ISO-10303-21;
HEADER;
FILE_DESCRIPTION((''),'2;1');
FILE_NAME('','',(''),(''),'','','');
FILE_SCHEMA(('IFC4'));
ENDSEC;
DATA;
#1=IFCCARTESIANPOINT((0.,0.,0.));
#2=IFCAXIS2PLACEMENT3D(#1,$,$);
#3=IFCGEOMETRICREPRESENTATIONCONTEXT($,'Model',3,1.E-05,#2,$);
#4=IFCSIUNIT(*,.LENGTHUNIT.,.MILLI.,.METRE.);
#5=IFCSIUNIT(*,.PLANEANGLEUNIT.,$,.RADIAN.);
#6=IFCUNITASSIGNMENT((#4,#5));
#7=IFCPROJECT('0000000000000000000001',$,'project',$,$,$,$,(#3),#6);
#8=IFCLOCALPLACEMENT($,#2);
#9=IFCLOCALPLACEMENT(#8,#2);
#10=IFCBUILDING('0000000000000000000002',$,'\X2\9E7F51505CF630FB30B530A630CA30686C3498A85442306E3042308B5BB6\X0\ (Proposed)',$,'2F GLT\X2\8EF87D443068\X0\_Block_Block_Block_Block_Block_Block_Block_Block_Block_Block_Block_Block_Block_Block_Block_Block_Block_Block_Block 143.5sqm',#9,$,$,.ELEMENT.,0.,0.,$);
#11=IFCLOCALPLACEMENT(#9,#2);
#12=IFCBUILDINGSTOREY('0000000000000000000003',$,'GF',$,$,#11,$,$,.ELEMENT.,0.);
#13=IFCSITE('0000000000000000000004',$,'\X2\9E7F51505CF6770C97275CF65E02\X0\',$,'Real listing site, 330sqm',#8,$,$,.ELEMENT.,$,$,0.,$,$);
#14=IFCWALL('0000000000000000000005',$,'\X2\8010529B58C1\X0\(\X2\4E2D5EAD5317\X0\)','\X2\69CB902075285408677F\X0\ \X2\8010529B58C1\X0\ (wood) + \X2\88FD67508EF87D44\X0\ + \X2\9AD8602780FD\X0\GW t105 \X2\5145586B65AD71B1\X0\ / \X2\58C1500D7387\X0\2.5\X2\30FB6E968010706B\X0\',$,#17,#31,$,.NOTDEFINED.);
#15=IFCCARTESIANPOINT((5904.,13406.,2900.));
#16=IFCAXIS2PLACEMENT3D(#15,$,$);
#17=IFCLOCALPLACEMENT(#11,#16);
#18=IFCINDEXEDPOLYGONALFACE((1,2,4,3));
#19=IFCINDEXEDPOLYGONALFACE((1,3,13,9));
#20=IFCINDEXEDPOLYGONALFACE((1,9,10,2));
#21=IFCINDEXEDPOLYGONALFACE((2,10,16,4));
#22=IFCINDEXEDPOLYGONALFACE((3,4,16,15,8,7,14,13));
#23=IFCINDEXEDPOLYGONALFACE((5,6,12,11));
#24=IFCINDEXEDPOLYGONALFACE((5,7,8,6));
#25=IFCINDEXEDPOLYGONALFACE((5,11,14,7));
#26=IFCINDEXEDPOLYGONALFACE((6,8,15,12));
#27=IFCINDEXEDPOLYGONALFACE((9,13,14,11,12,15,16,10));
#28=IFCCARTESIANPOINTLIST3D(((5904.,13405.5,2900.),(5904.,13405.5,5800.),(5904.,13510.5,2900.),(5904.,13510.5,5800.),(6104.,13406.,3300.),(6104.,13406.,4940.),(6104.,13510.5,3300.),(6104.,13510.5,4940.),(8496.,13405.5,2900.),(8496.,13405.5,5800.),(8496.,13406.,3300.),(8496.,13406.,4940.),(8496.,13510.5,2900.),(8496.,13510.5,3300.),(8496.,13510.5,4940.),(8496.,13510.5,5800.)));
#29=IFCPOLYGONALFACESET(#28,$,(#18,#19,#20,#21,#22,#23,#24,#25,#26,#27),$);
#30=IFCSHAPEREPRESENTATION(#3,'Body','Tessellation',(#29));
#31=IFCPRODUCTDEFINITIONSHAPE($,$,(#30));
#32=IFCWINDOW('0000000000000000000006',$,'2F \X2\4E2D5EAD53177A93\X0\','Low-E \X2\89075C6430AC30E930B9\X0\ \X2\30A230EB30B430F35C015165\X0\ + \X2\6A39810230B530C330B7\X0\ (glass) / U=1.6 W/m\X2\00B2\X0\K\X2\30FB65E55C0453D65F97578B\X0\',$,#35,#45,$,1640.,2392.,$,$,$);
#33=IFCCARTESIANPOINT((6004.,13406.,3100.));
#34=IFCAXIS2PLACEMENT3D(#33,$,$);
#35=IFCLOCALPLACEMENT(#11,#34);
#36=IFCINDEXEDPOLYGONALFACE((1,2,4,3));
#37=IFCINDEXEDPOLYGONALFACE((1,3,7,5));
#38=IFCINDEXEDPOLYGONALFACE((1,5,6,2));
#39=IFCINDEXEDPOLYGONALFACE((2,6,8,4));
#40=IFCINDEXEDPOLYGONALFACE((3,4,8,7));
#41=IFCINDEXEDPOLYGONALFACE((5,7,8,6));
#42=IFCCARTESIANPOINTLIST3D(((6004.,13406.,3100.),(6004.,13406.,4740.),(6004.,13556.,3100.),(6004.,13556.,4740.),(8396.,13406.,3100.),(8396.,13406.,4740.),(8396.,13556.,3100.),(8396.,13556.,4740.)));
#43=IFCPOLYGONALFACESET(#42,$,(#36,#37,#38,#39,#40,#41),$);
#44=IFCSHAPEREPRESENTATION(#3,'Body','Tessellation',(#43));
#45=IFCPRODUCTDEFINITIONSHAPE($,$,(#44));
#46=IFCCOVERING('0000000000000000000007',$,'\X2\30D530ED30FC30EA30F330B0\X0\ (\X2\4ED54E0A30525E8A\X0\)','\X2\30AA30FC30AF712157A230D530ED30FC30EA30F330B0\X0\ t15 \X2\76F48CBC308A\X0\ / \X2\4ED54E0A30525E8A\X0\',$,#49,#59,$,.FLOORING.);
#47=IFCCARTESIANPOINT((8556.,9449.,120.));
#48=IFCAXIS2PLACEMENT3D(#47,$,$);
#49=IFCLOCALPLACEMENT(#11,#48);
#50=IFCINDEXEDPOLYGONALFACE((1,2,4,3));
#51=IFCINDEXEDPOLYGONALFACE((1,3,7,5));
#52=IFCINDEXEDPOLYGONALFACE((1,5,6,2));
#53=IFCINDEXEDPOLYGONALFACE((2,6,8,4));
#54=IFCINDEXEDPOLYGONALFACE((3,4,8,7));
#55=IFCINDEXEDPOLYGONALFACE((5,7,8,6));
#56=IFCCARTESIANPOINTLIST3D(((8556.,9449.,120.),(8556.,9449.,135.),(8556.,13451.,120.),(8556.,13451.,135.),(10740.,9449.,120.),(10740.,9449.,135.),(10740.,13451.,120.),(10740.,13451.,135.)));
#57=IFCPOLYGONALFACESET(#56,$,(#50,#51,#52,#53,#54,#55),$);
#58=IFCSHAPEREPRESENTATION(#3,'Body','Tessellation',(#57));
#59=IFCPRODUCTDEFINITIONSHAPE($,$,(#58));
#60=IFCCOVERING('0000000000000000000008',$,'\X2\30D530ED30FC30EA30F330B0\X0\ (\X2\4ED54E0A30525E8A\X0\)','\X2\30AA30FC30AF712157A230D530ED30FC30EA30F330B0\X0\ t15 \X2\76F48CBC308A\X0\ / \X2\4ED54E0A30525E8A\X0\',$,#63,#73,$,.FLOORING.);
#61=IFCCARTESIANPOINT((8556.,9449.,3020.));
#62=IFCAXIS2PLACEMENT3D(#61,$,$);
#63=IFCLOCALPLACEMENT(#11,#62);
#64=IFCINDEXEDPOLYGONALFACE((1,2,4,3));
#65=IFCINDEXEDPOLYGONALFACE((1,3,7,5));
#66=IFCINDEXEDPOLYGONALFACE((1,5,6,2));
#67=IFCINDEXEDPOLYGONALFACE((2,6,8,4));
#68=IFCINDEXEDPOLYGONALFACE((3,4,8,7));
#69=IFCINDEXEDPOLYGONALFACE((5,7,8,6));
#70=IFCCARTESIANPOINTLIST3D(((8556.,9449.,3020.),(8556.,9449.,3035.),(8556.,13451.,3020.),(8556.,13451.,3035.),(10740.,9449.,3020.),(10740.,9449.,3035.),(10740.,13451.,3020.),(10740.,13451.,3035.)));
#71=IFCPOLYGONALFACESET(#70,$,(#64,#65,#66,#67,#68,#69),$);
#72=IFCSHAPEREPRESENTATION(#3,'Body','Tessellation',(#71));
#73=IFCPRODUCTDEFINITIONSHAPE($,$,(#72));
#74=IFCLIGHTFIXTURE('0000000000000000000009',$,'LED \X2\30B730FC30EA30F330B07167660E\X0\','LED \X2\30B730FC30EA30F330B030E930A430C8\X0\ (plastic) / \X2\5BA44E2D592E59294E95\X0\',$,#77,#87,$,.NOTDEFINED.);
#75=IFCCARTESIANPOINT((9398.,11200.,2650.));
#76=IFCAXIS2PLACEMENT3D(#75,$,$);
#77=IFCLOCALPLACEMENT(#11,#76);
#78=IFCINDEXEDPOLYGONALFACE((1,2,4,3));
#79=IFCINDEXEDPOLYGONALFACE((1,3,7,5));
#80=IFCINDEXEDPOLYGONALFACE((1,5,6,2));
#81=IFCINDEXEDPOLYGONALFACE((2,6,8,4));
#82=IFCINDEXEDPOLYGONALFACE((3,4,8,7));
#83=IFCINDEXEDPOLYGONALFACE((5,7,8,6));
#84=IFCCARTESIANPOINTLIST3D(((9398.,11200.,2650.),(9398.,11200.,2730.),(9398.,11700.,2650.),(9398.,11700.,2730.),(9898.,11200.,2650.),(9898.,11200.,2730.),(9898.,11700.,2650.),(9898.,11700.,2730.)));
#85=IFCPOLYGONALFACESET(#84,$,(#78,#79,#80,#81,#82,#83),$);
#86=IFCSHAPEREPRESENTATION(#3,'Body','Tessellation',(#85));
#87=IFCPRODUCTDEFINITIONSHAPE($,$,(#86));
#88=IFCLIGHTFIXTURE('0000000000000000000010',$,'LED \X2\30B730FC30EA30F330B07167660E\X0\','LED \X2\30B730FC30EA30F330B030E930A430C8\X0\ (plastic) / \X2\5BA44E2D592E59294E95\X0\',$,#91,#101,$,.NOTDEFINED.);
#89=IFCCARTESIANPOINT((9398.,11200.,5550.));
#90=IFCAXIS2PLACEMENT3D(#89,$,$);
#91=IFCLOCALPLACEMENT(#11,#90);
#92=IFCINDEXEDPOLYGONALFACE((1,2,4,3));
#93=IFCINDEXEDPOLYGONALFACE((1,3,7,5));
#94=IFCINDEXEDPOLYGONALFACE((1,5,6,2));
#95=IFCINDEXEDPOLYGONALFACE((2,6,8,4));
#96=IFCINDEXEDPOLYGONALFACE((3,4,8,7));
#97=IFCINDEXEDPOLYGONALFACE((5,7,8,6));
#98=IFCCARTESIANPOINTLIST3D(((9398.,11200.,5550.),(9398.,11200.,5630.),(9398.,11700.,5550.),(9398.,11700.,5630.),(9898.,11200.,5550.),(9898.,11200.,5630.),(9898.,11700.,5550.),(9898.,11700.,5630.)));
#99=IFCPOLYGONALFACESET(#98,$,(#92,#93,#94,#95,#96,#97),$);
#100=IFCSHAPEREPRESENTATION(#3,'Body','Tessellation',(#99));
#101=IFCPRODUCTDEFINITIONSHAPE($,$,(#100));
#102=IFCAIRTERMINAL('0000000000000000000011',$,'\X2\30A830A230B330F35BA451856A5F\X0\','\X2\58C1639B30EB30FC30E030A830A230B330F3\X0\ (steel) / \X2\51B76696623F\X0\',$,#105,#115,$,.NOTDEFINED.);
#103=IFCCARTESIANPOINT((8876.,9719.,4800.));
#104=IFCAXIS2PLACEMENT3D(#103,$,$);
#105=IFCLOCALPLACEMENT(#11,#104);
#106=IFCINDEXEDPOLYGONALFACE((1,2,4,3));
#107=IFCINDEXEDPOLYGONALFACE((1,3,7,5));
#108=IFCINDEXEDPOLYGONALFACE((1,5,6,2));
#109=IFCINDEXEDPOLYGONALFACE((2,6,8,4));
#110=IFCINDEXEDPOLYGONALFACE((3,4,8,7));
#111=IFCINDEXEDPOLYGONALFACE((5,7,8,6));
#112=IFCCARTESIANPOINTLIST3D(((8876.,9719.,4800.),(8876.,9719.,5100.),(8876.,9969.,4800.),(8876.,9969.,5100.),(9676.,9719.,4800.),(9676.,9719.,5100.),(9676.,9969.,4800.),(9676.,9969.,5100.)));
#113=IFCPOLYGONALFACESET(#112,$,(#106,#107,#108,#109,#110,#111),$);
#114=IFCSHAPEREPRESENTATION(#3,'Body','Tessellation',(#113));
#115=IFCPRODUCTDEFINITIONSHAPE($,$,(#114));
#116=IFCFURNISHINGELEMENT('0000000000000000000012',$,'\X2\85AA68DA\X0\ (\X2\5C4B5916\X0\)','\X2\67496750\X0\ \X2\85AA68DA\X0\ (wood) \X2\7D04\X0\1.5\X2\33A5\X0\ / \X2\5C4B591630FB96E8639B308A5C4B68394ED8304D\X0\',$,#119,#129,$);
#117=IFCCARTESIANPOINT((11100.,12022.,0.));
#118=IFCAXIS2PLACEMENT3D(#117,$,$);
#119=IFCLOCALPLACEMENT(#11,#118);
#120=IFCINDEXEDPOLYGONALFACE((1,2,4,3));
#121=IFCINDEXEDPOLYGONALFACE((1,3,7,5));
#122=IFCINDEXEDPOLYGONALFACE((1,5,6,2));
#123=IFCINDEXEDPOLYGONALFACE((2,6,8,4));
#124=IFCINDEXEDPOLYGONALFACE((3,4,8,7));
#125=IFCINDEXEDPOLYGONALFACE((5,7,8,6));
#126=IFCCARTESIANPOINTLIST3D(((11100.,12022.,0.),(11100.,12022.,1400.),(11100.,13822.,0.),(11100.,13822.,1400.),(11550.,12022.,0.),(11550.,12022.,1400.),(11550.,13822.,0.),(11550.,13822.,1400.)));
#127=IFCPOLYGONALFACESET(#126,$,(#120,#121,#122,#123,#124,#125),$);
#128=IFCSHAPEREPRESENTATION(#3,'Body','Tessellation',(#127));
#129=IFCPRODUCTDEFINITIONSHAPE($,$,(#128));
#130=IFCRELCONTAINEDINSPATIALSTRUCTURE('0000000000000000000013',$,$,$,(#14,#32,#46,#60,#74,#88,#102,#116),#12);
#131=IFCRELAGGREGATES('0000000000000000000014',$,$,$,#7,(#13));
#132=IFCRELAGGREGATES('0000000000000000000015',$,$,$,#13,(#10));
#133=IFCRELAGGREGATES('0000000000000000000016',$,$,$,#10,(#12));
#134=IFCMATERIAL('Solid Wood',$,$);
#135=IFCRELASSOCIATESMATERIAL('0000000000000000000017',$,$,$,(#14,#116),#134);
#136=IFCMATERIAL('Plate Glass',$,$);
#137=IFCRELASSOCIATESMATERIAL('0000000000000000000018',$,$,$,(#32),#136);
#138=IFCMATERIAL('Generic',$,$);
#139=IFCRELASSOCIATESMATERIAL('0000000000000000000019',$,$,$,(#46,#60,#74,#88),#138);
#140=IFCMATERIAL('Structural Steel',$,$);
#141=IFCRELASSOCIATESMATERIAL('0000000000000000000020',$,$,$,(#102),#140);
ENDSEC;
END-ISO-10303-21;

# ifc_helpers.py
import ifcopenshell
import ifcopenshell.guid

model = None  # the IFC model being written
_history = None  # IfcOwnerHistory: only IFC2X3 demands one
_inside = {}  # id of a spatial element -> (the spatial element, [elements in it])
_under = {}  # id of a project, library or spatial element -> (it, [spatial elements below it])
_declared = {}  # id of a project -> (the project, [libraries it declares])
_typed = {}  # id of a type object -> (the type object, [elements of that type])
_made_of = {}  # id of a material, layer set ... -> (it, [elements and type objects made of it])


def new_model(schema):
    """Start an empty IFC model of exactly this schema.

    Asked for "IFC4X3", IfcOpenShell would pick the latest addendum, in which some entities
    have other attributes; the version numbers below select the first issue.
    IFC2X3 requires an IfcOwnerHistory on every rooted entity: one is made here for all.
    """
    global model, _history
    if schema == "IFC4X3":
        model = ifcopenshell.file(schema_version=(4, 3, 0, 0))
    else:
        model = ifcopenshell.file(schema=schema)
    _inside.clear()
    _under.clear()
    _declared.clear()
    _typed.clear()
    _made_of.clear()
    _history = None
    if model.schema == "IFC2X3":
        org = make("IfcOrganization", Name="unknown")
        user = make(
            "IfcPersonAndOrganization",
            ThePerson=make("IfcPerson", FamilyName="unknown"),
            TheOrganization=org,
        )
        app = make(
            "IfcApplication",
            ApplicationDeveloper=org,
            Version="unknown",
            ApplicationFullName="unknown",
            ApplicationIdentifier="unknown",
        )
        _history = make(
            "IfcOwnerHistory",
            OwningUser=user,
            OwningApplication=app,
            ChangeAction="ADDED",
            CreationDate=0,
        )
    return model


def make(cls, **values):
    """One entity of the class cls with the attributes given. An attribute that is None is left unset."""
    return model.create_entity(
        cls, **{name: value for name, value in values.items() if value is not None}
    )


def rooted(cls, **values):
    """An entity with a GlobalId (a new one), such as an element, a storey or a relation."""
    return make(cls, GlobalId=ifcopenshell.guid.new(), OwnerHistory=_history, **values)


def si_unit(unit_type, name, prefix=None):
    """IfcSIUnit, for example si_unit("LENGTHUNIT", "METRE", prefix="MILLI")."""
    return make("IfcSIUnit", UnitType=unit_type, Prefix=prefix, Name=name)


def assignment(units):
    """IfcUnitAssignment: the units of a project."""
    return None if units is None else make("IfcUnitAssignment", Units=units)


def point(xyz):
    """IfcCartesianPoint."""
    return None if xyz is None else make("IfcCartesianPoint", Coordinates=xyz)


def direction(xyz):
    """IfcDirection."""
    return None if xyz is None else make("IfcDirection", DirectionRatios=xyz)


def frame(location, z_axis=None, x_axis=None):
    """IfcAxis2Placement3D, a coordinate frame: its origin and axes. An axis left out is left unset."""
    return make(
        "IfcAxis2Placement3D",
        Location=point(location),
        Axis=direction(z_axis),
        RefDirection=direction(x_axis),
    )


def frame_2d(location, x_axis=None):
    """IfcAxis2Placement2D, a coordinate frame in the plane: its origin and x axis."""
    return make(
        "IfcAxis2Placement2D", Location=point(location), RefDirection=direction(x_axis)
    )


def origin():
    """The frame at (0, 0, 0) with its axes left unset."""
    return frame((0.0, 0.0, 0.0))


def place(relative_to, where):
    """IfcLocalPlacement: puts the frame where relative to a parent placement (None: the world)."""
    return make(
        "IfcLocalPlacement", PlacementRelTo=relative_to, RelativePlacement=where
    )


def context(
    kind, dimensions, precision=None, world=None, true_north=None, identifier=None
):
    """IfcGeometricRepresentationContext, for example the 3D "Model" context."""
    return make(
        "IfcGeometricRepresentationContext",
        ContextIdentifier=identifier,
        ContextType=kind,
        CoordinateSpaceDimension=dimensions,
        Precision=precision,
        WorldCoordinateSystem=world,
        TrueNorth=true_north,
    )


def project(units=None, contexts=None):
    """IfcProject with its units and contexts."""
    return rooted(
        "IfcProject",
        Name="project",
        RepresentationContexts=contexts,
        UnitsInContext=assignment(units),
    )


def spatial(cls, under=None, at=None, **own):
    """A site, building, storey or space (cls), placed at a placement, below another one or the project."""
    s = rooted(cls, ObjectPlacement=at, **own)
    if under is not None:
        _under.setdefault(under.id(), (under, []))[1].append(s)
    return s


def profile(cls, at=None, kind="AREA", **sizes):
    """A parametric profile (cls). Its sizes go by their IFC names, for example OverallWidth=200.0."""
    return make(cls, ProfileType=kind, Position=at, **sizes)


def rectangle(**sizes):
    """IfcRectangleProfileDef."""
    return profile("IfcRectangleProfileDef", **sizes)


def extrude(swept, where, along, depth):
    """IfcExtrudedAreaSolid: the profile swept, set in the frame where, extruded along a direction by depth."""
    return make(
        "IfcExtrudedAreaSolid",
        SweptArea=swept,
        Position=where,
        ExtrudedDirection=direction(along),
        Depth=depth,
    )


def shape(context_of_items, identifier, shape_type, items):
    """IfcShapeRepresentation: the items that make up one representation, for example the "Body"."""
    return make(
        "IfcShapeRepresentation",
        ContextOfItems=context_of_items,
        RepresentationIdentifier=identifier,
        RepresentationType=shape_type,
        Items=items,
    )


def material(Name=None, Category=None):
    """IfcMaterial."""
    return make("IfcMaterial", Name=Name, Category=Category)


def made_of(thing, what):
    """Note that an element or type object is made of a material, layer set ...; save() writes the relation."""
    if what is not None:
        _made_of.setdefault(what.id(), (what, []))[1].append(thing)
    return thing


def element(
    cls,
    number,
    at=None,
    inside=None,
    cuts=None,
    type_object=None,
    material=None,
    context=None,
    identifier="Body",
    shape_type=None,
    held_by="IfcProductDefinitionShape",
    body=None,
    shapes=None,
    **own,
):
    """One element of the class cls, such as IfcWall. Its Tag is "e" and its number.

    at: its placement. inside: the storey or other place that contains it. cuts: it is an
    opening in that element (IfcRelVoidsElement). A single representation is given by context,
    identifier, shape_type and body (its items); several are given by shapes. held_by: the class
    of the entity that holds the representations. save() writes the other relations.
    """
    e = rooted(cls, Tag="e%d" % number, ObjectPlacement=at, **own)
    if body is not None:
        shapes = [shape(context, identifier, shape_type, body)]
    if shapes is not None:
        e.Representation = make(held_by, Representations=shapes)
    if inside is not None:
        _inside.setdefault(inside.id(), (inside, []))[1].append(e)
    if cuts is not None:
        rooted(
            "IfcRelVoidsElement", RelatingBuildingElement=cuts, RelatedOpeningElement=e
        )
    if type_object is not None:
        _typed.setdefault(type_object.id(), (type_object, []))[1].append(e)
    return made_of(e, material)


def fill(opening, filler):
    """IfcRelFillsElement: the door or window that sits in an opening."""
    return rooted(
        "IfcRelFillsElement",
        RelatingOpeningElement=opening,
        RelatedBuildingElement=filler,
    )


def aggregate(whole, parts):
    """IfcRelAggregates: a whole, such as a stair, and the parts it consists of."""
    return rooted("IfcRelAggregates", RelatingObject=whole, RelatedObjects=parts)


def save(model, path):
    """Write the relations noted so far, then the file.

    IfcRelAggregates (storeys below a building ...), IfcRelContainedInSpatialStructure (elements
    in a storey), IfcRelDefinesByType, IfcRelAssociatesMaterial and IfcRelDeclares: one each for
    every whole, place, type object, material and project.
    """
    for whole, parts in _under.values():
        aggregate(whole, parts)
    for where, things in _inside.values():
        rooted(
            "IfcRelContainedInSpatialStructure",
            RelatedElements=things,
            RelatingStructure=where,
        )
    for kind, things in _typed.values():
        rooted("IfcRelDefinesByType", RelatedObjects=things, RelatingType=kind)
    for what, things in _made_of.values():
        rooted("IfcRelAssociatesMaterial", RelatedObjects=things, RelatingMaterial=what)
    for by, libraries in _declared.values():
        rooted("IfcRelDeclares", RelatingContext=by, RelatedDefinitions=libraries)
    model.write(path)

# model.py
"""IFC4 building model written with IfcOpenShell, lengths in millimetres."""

from ifc_helpers import new_model, si_unit, frame, frame_2d, origin, place, context, project, spatial, rectangle, extrude, material, element, fill, save


model = new_model("IFC4")

# Units and contexts
model_context = context("Model", 3, precision=1e-05, world=origin())
ifc_project = project(units=[si_unit("LENGTHUNIT", "METRE", prefix="MILLI"), si_unit("PLANEANGLEUNIT", "RADIAN")], contexts=[model_context])

# Site, building, storey
site_placement = place(None, origin())
site = spatial("IfcSite", under=ifc_project, at=site_placement, Name="鹿児島県霧島市", ObjectType="Real listing site, 330sqm", CompositionType="ELEMENT", RefElevation=0.0)
building_placement = place(site_placement, origin())
building = spatial("IfcBuilding", under=site, at=building_placement, Name="鹿児島・サウナと水風呂のある家 (Proposed)", ObjectType="2F GLT軸組と_Block_Block_Block_Block_Block_Block_Block_Block_Block_Block_Block_Block_Block_Block_Block_Block_Block_Block_Block 143.5sqm", CompositionType="ELEMENT", ElevationOfRefHeight=0.0, ElevationOfTerrain=0.0)
storey_placement = place(building_placement, origin())
storey = spatial("IfcBuildingStorey", under=building, at=storey_placement, Name="GF", CompositionType="ELEMENT", Elevation=0.0)

# Shared definitions
ifc_material_1 = material(Name="Solid Wood")

# Wall, opening, window
ifc_material_2 = material(Name="Plate Glass")
wall_1_placement = place(storey_placement, frame((5904.0, 13406.0, 2900.0)))
wall_1 = element("IfcWall", 1, at=wall_1_placement, inside=storey, material=ifc_material_1, Name="耐力壁(中庭北)", Description="構造用合板 耐力壁 (wood) + 製材軸組 + 高性能GW t105 充填断熱 / 壁倍率2.5・準耐火", PredefinedType="NOTDEFINED", context=model_context, shape_type="SweptSolid", body=[
    extrude(rectangle(XDim=2592.0, YDim=105.0, at=frame_2d((1296.0, 52.0))), frame((5904.0, 13406.0, 2900.0)), (0.0, 0.0, 1.0), 2900.0),
])
opening_1_placement = place(storey_placement, frame((6004.0, 13406.0, 3100.0)))
opening_1 = element("IfcOpeningElement", 2, at=opening_1_placement, cuts=wall_1, PredefinedType="NOTDEFINED", context=model_context, shape_type="SweptSolid", body=[
    extrude(rectangle(XDim=2392.0, YDim=150.0, at=frame_2d((1196.0, 75.0))), frame((6004.0, 13406.0, 3100.0)), (0.0, 0.0, 1.0), 1640.0),
])
window_1_placement = place(storey_placement, frame((6004.0, 13406.0, 3100.0)))
window_1 = element("IfcWindow", 3, at=window_1_placement, inside=storey, material=ifc_material_2, Name="2F 中庭北窓", Description="Low-E 複層ガラス アルゴン封入 + 樹脂サッシ (glass) / U=1.6 W/m²K・日射取得型", OverallHeight=1640.0, OverallWidth=2392.0, context=model_context, shape_type="SweptSolid", body=[
    extrude(rectangle(XDim=2392.0, YDim=150.0, at=frame_2d((1196.0, 75.0))), frame((6004.0, 13406.0, 3100.0)), (0.0, 0.0, 1.0), 1640.0),
])
fill(opening_1, window_1)

# Coverings
ifc_material_3 = material(Name="Generic")
covering_1_placement = place(storey_placement, frame((8556.0, 9449.0, 120.0)))
element("IfcCovering", 4, at=covering_1_placement, inside=storey, material=ifc_material_3, Name="フローリング (仕上げ床)", Description="オーク無垢フローリング t15 直貼り / 仕上げ床", PredefinedType="FLOORING", context=model_context, shape_type="SweptSolid", body=[
    extrude(rectangle(XDim=2184.0, YDim=4002.0, at=frame_2d((1092.0, 2001.0))), frame((8556.0, 9449.0, 120.0)), (0.0, 0.0, 1.0), 15.0),
])
covering_2_placement = place(storey_placement, frame((8556.0, 9449.0, 3020.0)))
element("IfcCovering", 5, at=covering_2_placement, inside=storey, material=ifc_material_3, Name="フローリング (仕上げ床)", Description="オーク無垢フローリング t15 直貼り / 仕上げ床", PredefinedType="FLOORING", context=model_context, shape_type="SweptSolid", body=[
    extrude(rectangle(XDim=2184.0, YDim=4002.0, at=frame_2d((1092.0, 2001.0))), frame((8556.0, 9449.0, 3020.0)), (0.0, 0.0, 1.0), 15.0),
])

# Light fixtures
light_fixture_1_placement = place(storey_placement, frame((9398.0, 11200.0, 2650.0)))
element("IfcLightFixture", 6, at=light_fixture_1_placement, inside=storey, material=ifc_material_3, Name="LED シーリング照明", Description="LED シーリングライト (plastic) / 室中央天井", PredefinedType="NOTDEFINED", context=model_context, shape_type="SweptSolid", body=[
    extrude(rectangle(XDim=500.0, YDim=500.0, at=frame_2d((250.0, 250.0))), frame((9398.0, 11200.0, 2650.0)), (0.0, 0.0, 1.0), 80.0),
])
light_fixture_2_placement = place(storey_placement, frame((9398.0, 11200.0, 5550.0)))
element("IfcLightFixture", 7, at=light_fixture_2_placement, inside=storey, material=ifc_material_3, Name="LED シーリング照明", Description="LED シーリングライト (plastic) / 室中央天井", PredefinedType="NOTDEFINED", context=model_context, shape_type="SweptSolid", body=[
    extrude(rectangle(XDim=500.0, YDim=500.0, at=frame_2d((250.0, 250.0))), frame((9398.0, 11200.0, 5550.0)), (0.0, 0.0, 1.0), 80.0),
])

# Air terminal
ifc_material_4 = material(Name="Structural Steel")
air_terminal_placement = place(storey_placement, frame((8876.0, 9719.0, 4800.0)))
element("IfcAirTerminal", 8, at=air_terminal_placement, inside=storey, material=ifc_material_4, Name="エアコン室内機", Description="壁掛ルームエアコン (steel) / 冷暖房", PredefinedType="NOTDEFINED", context=model_context, shape_type="SweptSolid", body=[
    extrude(rectangle(XDim=800.0, YDim=250.0, at=frame_2d((400.0, 125.0))), frame((8876.0, 9719.0, 4800.0)), (0.0, 0.0, 1.0), 300.0),
])

# Furnishing element
furnishing_placement = place(storey_placement, frame((11100.0, 12022.0, 0.0)))
element("IfcFurnishingElement", 9, at=furnishing_placement, inside=storey, material=ifc_material_1, Name="薪棚 (屋外)", Description="杉材 薪棚 (wood) 約1.5㎥ / 屋外・雨掛り屋根付き", context=model_context, shape_type="SweptSolid", body=[
    extrude(rectangle(XDim=450.0, YDim=1800.0, at=frame_2d((225.0, 900.0))), frame((11100.0, 12022.0, 0.0)), (0.0, 0.0, 1.0), 1400.0),
])

save(model, "model.ifc")
